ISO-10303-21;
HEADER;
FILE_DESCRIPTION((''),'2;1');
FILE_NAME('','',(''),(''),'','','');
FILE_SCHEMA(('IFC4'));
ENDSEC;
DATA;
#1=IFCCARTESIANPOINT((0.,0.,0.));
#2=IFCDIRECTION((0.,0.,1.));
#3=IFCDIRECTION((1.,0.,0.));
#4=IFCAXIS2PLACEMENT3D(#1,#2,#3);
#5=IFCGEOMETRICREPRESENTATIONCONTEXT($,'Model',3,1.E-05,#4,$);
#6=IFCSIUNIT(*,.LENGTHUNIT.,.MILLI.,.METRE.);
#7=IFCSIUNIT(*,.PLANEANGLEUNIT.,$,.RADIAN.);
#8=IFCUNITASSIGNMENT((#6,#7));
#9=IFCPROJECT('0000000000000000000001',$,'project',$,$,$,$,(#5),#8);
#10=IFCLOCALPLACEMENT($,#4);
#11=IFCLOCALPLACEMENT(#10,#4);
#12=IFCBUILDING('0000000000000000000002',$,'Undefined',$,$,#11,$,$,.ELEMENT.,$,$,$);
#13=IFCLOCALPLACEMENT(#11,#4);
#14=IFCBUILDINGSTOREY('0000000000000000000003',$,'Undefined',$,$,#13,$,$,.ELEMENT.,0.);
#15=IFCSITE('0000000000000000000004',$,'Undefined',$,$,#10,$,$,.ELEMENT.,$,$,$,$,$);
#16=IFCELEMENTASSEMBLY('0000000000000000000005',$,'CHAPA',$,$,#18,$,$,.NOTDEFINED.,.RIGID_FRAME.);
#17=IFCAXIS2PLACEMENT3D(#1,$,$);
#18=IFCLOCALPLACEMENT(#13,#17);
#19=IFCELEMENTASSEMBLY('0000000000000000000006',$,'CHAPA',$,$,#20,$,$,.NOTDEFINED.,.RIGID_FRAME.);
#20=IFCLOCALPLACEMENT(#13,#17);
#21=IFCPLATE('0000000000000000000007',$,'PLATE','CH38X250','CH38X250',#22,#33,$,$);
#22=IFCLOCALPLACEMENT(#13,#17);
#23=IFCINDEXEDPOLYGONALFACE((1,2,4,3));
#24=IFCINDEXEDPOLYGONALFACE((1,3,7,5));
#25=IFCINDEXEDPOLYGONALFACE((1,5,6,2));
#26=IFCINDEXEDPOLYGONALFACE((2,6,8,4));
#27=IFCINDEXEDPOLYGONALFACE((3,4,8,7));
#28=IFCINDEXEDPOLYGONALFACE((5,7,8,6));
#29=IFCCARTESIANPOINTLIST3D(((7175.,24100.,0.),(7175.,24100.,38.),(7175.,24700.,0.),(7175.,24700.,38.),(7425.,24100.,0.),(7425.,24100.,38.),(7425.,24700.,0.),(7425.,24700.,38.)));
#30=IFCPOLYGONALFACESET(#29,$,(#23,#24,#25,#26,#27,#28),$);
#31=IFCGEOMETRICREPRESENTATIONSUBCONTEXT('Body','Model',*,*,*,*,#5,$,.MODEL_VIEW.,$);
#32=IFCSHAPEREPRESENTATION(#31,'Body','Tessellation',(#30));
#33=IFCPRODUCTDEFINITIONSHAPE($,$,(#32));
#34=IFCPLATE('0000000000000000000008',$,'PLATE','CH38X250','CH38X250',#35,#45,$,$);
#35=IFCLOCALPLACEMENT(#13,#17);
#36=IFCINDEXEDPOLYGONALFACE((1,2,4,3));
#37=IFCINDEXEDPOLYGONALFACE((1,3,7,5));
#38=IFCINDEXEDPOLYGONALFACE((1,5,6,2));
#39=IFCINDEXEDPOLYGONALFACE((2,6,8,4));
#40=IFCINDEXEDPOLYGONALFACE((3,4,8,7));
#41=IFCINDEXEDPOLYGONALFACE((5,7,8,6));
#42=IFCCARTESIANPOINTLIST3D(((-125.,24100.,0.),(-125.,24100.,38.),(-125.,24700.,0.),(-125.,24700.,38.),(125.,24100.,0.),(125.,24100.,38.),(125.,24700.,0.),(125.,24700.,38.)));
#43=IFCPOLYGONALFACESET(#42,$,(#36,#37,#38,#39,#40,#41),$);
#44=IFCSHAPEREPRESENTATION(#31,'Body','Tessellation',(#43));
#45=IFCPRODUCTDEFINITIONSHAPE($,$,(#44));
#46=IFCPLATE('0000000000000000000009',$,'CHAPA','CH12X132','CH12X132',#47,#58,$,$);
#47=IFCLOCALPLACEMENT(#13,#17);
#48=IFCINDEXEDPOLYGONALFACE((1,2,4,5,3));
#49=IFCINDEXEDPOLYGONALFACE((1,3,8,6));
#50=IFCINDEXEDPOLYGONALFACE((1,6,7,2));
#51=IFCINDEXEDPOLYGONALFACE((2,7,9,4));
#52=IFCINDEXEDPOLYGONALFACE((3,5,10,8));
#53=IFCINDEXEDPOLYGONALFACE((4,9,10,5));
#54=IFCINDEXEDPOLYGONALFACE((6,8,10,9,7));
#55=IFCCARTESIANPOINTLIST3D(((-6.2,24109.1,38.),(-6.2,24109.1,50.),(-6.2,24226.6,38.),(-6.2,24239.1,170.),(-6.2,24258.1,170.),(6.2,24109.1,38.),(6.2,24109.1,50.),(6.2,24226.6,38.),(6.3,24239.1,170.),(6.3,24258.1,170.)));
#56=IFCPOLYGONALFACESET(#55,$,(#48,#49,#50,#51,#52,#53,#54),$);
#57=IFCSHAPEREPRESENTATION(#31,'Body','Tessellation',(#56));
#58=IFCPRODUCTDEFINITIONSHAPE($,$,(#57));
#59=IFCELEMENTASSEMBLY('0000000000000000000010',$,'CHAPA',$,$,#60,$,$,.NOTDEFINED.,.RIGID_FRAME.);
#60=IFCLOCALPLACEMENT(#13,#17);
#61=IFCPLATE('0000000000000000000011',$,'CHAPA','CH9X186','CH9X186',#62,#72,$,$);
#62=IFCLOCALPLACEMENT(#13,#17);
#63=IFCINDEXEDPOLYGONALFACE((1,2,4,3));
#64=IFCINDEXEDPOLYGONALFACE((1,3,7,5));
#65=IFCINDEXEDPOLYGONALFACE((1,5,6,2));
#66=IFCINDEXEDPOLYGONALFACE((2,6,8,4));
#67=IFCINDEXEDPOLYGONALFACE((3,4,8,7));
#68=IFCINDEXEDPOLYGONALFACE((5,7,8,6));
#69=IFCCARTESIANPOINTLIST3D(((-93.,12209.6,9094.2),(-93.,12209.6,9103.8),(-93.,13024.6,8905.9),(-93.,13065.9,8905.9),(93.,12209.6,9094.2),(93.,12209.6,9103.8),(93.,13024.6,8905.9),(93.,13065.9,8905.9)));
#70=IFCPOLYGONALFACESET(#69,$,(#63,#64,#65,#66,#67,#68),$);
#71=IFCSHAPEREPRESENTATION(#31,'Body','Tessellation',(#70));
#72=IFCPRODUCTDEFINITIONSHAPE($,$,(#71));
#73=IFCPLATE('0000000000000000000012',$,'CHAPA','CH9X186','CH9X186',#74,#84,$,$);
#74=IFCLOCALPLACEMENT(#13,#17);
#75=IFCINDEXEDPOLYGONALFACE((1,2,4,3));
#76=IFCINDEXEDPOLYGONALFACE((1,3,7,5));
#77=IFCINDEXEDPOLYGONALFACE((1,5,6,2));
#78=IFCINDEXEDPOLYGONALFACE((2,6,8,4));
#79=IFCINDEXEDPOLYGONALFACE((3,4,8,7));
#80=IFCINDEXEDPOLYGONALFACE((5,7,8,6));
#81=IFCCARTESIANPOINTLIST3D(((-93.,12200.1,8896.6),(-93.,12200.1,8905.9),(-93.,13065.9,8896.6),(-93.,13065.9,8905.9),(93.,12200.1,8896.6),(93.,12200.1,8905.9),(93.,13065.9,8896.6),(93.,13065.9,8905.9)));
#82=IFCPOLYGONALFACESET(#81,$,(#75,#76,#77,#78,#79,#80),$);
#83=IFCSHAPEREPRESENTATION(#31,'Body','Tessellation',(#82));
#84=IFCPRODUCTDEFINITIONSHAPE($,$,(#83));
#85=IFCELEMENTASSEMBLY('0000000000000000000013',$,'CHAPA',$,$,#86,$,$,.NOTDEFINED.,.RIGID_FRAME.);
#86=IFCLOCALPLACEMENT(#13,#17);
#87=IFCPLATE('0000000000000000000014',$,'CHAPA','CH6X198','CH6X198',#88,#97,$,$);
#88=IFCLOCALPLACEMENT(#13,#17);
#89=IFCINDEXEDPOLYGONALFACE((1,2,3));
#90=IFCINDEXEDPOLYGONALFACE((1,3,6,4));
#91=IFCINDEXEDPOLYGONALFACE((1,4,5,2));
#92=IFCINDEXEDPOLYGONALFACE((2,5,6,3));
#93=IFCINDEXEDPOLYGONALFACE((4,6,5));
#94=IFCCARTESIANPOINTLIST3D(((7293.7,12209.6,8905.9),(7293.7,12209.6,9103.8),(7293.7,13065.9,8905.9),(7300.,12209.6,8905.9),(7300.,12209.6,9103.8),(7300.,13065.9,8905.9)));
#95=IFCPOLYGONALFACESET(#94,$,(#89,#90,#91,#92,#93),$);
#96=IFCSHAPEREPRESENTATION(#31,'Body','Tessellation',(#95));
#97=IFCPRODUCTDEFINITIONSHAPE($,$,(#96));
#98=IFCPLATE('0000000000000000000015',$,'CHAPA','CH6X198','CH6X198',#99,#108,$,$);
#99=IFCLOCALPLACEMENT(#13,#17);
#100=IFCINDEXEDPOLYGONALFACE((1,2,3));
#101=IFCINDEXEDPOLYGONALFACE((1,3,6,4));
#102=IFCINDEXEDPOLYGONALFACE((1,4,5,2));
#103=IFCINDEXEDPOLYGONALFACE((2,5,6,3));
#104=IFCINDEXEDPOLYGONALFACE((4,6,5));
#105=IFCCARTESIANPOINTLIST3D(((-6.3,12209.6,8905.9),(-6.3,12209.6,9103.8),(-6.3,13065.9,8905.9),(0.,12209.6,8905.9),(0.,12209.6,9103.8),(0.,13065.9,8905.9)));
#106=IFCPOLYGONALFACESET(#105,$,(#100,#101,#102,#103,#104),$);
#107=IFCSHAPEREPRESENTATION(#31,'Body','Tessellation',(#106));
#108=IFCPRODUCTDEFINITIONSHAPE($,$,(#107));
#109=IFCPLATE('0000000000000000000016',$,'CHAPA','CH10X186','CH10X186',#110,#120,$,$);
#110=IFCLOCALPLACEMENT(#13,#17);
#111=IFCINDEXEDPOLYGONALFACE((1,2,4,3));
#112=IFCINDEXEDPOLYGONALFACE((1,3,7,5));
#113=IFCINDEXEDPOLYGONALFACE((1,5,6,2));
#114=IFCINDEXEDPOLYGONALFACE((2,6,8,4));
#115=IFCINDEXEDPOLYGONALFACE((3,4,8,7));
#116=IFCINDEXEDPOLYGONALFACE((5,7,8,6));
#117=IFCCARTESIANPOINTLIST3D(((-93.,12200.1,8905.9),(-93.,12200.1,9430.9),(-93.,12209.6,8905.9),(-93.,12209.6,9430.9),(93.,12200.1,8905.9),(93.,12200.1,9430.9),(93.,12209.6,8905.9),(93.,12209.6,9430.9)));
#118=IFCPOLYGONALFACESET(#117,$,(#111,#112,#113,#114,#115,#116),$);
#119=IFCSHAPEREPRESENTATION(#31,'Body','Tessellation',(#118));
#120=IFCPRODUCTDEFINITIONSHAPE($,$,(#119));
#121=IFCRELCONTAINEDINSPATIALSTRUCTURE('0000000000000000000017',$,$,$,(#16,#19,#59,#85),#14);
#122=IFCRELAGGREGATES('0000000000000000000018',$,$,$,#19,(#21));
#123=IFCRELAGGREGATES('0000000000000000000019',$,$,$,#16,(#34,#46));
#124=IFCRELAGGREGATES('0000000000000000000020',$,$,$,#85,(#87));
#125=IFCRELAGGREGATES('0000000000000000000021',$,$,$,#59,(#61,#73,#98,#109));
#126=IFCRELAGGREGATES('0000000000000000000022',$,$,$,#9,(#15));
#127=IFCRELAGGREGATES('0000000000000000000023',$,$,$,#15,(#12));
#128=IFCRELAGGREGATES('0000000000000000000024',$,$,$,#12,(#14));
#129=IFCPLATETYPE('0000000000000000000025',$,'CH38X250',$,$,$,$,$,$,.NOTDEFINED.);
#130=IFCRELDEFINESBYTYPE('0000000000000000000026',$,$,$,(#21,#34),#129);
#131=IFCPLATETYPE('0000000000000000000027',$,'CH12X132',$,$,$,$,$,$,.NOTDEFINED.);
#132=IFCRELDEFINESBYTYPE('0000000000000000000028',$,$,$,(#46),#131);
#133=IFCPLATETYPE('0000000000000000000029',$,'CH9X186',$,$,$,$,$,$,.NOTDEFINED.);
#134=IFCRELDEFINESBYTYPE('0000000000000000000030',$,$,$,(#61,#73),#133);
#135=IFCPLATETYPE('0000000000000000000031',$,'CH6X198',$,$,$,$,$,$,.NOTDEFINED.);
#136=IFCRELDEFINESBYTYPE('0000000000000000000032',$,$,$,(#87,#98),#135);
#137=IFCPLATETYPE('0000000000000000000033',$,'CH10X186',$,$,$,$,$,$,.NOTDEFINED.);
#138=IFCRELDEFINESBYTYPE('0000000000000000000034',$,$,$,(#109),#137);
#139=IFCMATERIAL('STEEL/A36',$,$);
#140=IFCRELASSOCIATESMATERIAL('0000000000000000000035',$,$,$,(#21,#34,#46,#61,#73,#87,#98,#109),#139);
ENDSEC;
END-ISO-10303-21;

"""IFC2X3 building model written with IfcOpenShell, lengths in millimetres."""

from ifc_helpers import new_model, si_unit, frame, origin_with_axes, place, context, subcontext, project, spatial, polyline, outline, extrude, clip, halfspace, material, type_object, element, aggregate, save


model = new_model("IFC2X3")

# Units and contexts
model_context = context("Model", 3, precision=1e-05, world=origin_with_axes())
body_context = subcontext(model_context, "Body", "Model", "MODEL_VIEW")
ifc_project = project(units=[si_unit("LENGTHUNIT", "METRE", prefix="MILLI"), si_unit("PLANEANGLEUNIT", "RADIAN")], contexts=[model_context])

# Site, building, storey
site_placement = place(None, origin_with_axes())
site = spatial("IfcSite", under=ifc_project, at=site_placement, Name="Undefined", CompositionType="ELEMENT")
building_placement = place(site_placement, origin_with_axes())
building = spatial("IfcBuilding", under=site, at=building_placement, Name="Undefined", CompositionType="ELEMENT")
storey_placement = place(building_placement, origin_with_axes())
storey = spatial("IfcBuildingStorey", under=building, at=storey_placement, Name="Undefined", CompositionType="ELEMENT", Elevation=0.0)

# Element assembly
assembly_1_placement = place(storey_placement, origin_with_axes())
assembly_1 = element("IfcElementAssembly", 1, at=assembly_1_placement, inside=storey, Name="CHAPA", AssemblyPlace="NOTDEFINED", PredefinedType="RIGID_FRAME")

# Element assembly, plate
assembly_2_placement = place(storey_placement, origin_with_axes())
assembly_2 = element("IfcElementAssembly", 2, at=assembly_2_placement, inside=storey, Name="CHAPA", AssemblyPlace="NOTDEFINED", PredefinedType="RIGID_FRAME")
ifc_material_1 = material(Name="STEEL/A36")
plate_type_1 = type_object("IfcPlateType", Name="CH38X250", PredefinedType="NOTDEFINED")
plate_1_placement = place(assembly_2_placement, frame((7175.0, 24700.0, 19.0), z_axis=(0.0, 0.0, 1.0), x_axis=(0.0, -1.0, 0.0)))
plate_1 = element("IfcPlate", 3, at=plate_1_placement, type_object=plate_type_1, material=ifc_material_1, Name="PLATE", Description="CH38X250", ObjectType="CH38X250", context=body_context, shape_type="SweptSolid", body=[
    extrude(outline(polyline([(0.0, 0.0), (600.0, 0.0), (600.0, 250.0), (0.0, 250.0), (0.0, 0.0)])), frame((0.0, 0.0, -19.0), z_axis=(0.0, 0.0, 1.0), x_axis=(1.0, 0.0, 0.0)), (0.0, 0.0, 1.0), 38.0),
])
aggregate(assembly_2, [plate_1])

# Plates
plate_2_placement = place(assembly_1_placement, frame((-125.0, 24700.0, 19.0), z_axis=(0.0, 0.0, 1.0), x_axis=(0.0, -1.0, 0.0)))
plate_2 = element("IfcPlate", 4, at=plate_2_placement, type_object=plate_type_1, material=ifc_material_1, Name="PLATE", Description="CH38X250", ObjectType="CH38X250", context=body_context, shape_type="SweptSolid", body=[
    extrude(outline(polyline([(0.0, 0.0), (600.0, 0.0), (600.0, 250.0), (0.0, 250.0), (0.0, 0.0)])), frame((0.0, 0.0, -19.0), z_axis=(0.0, 0.0, 1.0), x_axis=(1.0, 0.0, 0.0)), (0.0, 0.0, 1.0), 38.0),
])
plate_type_2 = type_object("IfcPlateType", Name="CH12X132", PredefinedType="NOTDEFINED")
plate_3_placement = place(assembly_1_placement, frame((0.0, 24226.6, 38.0), z_axis=(-1.0, 0.0, 0.0), x_axis=(0.0, -1.0, 0.0)))
plate_3 = element("IfcPlate", 5, at=plate_3_placement, type_object=plate_type_2, material=ifc_material_1, Name="CHAPA", Description="CH12X132", ObjectType="CH12X132", context=body_context, shape_type="SweptSolid", body=[
    extrude(outline(polyline([(0.0, 0.0), (117.5, 0.0), (117.5, 12.0), (-12.5, 132.0), (-31.6, 132.0), (0.0, 0.0)])), frame((0.0, 0.0, -6.2), z_axis=(0.0, 0.0, 1.0), x_axis=(1.0, 0.0, 0.0)), (0.0, 0.0, 1.0), 12.5),
])

# Element assembly, plates
assembly_3_placement = place(storey_placement, origin_with_axes())
assembly_3 = element("IfcElementAssembly", 6, at=assembly_3_placement, inside=storey, Name="CHAPA", AssemblyPlace="NOTDEFINED", PredefinedType="RIGID_FRAME")
plate_type_3 = type_object("IfcPlateType", Name="CH9X186", PredefinedType="NOTDEFINED")
plate_4_placement = place(assembly_3_placement, frame((93.0, 12208.6, 9099.3), z_axis=(0.0, -0.225125, -0.97433), x_axis=(-1.0, 0.0, 0.0)))
plate_4 = element("IfcPlate", 7, at=plate_4_placement, type_object=plate_type_3, material=ifc_material_1, Name="CHAPA", Description="CH9X186", ObjectType="CH9X186", context=body_context, shape_type="Clipping", body=[
    clip(clip(extrude(outline(polyline([(0.0, 0.0), (186.0, 0.0), (186.0, 878.9), (0.0, 878.9), (0.0, 0.0)])), frame((0.0, 0.0, -4.7), z_axis=(0.0, 0.0, 1.0), x_axis=(1.0, 0.0, 0.0)), (0.0, 0.0, 1.0), 9.3), halfspace(frame((186.0, -500.0, 314.0), z_axis=(0.0, 0.225128, 0.974329), x_axis=(-1.0, 0.0, 0.0)), False)), halfspace(frame((0.0, 2.1, 4.7), z_axis=(0.0, -0.97433, 0.225125), x_axis=(1.0, 0.0, 0.0)), False)),
])
plate_5_placement = place(assembly_3_placement, frame((93.0, 12200.1, 8901.3), z_axis=(0.0, 0.0, -1.0), x_axis=(-1.0, 0.0, 0.0)))
plate_5 = element("IfcPlate", 8, at=plate_5_placement, type_object=plate_type_3, material=ifc_material_1, Name="CHAPA", Description="CH9X186", ObjectType="CH9X186", context=body_context, shape_type="SweptSolid", body=[
    extrude(outline(polyline([(0.0, 0.0), (186.0, 0.0), (186.0, 865.8), (0.0, 865.8), (0.0, 0.0)])), frame((0.0, 0.0, -4.7), z_axis=(0.0, 0.0, 1.0), x_axis=(1.0, 0.0, 0.0)), (0.0, 0.0, 1.0), 9.3),
])

# Element assembly, plate
assembly_4_placement = place(storey_placement, origin_with_axes())
assembly_4 = element("IfcElementAssembly", 9, at=assembly_4_placement, inside=storey, Name="CHAPA", AssemblyPlace="NOTDEFINED", PredefinedType="RIGID_FRAME")
plate_type_4 = type_object("IfcPlateType", Name="CH6X198", PredefinedType="NOTDEFINED")
plate_6_placement = place(assembly_4_placement, frame((7296.9, 13065.9, 8905.9), z_axis=(-1.0, 0.0, 0.0), x_axis=(0.0, -1.0, 0.0)))
plate_6 = element("IfcPlate", 10, at=plate_6_placement, type_object=plate_type_4, material=ifc_material_1, Name="CHAPA", Description="CH6X198", ObjectType="CH6X198", context=body_context, shape_type="SweptSolid", body=[
    extrude(outline(polyline([(0.0, 0.0), (856.3, 0.0), (856.3, 197.9), (0.0, 0.0)])), frame((0.0, 0.0, -3.1), z_axis=(0.0, 0.0, 1.0), x_axis=(1.0, 0.0, 0.0)), (0.0, 0.0, 1.0), 6.3),
])

# Plates
plate_7_placement = place(assembly_3_placement, frame((-3.1, 13065.9, 8905.9), z_axis=(-1.0, 0.0, 0.0), x_axis=(0.0, -1.0, 0.0)))
plate_7 = element("IfcPlate", 11, at=plate_7_placement, type_object=plate_type_4, material=ifc_material_1, Name="CHAPA", Description="CH6X198", ObjectType="CH6X198", context=body_context, shape_type="SweptSolid", body=[
    extrude(outline(polyline([(0.0, 0.0), (856.3, 0.0), (856.3, 197.9), (0.0, 0.0)])), frame((0.0, 0.0, -3.1), z_axis=(0.0, 0.0, 1.0), x_axis=(1.0, 0.0, 0.0)), (0.0, 0.0, 1.0), 6.3),
])
plate_type_5 = type_object("IfcPlateType", Name="CH10X186", PredefinedType="NOTDEFINED")
plate_8_placement = place(assembly_3_placement, frame((93.0, 12204.8, 9430.9), z_axis=(0.0, -1.0, 0.0), x_axis=(-1.0, 0.0, 0.0)))
plate_8 = element("IfcPlate", 12, at=plate_8_placement, type_object=plate_type_5, material=ifc_material_1, Name="CHAPA", Description="CH10X186", ObjectType="CH10X186", context=body_context, shape_type="SweptSolid", body=[
    extrude(outline(polyline([(0.0, 0.0), (186.0, 0.0), (186.0, 525.0), (0.0, 525.0), (0.0, 0.0)])), frame((0.0, 0.0, -4.8), z_axis=(0.0, 0.0, 1.0), x_axis=(1.0, 0.0, 0.0)), (0.0, 0.0, 1.0), 9.5),
])

aggregate(assembly_1, [plate_2, plate_3])
aggregate(assembly_4, [plate_6])
aggregate(assembly_3, [plate_4, plate_5, plate_7, plate_8])

save(model, "model.ifc")
